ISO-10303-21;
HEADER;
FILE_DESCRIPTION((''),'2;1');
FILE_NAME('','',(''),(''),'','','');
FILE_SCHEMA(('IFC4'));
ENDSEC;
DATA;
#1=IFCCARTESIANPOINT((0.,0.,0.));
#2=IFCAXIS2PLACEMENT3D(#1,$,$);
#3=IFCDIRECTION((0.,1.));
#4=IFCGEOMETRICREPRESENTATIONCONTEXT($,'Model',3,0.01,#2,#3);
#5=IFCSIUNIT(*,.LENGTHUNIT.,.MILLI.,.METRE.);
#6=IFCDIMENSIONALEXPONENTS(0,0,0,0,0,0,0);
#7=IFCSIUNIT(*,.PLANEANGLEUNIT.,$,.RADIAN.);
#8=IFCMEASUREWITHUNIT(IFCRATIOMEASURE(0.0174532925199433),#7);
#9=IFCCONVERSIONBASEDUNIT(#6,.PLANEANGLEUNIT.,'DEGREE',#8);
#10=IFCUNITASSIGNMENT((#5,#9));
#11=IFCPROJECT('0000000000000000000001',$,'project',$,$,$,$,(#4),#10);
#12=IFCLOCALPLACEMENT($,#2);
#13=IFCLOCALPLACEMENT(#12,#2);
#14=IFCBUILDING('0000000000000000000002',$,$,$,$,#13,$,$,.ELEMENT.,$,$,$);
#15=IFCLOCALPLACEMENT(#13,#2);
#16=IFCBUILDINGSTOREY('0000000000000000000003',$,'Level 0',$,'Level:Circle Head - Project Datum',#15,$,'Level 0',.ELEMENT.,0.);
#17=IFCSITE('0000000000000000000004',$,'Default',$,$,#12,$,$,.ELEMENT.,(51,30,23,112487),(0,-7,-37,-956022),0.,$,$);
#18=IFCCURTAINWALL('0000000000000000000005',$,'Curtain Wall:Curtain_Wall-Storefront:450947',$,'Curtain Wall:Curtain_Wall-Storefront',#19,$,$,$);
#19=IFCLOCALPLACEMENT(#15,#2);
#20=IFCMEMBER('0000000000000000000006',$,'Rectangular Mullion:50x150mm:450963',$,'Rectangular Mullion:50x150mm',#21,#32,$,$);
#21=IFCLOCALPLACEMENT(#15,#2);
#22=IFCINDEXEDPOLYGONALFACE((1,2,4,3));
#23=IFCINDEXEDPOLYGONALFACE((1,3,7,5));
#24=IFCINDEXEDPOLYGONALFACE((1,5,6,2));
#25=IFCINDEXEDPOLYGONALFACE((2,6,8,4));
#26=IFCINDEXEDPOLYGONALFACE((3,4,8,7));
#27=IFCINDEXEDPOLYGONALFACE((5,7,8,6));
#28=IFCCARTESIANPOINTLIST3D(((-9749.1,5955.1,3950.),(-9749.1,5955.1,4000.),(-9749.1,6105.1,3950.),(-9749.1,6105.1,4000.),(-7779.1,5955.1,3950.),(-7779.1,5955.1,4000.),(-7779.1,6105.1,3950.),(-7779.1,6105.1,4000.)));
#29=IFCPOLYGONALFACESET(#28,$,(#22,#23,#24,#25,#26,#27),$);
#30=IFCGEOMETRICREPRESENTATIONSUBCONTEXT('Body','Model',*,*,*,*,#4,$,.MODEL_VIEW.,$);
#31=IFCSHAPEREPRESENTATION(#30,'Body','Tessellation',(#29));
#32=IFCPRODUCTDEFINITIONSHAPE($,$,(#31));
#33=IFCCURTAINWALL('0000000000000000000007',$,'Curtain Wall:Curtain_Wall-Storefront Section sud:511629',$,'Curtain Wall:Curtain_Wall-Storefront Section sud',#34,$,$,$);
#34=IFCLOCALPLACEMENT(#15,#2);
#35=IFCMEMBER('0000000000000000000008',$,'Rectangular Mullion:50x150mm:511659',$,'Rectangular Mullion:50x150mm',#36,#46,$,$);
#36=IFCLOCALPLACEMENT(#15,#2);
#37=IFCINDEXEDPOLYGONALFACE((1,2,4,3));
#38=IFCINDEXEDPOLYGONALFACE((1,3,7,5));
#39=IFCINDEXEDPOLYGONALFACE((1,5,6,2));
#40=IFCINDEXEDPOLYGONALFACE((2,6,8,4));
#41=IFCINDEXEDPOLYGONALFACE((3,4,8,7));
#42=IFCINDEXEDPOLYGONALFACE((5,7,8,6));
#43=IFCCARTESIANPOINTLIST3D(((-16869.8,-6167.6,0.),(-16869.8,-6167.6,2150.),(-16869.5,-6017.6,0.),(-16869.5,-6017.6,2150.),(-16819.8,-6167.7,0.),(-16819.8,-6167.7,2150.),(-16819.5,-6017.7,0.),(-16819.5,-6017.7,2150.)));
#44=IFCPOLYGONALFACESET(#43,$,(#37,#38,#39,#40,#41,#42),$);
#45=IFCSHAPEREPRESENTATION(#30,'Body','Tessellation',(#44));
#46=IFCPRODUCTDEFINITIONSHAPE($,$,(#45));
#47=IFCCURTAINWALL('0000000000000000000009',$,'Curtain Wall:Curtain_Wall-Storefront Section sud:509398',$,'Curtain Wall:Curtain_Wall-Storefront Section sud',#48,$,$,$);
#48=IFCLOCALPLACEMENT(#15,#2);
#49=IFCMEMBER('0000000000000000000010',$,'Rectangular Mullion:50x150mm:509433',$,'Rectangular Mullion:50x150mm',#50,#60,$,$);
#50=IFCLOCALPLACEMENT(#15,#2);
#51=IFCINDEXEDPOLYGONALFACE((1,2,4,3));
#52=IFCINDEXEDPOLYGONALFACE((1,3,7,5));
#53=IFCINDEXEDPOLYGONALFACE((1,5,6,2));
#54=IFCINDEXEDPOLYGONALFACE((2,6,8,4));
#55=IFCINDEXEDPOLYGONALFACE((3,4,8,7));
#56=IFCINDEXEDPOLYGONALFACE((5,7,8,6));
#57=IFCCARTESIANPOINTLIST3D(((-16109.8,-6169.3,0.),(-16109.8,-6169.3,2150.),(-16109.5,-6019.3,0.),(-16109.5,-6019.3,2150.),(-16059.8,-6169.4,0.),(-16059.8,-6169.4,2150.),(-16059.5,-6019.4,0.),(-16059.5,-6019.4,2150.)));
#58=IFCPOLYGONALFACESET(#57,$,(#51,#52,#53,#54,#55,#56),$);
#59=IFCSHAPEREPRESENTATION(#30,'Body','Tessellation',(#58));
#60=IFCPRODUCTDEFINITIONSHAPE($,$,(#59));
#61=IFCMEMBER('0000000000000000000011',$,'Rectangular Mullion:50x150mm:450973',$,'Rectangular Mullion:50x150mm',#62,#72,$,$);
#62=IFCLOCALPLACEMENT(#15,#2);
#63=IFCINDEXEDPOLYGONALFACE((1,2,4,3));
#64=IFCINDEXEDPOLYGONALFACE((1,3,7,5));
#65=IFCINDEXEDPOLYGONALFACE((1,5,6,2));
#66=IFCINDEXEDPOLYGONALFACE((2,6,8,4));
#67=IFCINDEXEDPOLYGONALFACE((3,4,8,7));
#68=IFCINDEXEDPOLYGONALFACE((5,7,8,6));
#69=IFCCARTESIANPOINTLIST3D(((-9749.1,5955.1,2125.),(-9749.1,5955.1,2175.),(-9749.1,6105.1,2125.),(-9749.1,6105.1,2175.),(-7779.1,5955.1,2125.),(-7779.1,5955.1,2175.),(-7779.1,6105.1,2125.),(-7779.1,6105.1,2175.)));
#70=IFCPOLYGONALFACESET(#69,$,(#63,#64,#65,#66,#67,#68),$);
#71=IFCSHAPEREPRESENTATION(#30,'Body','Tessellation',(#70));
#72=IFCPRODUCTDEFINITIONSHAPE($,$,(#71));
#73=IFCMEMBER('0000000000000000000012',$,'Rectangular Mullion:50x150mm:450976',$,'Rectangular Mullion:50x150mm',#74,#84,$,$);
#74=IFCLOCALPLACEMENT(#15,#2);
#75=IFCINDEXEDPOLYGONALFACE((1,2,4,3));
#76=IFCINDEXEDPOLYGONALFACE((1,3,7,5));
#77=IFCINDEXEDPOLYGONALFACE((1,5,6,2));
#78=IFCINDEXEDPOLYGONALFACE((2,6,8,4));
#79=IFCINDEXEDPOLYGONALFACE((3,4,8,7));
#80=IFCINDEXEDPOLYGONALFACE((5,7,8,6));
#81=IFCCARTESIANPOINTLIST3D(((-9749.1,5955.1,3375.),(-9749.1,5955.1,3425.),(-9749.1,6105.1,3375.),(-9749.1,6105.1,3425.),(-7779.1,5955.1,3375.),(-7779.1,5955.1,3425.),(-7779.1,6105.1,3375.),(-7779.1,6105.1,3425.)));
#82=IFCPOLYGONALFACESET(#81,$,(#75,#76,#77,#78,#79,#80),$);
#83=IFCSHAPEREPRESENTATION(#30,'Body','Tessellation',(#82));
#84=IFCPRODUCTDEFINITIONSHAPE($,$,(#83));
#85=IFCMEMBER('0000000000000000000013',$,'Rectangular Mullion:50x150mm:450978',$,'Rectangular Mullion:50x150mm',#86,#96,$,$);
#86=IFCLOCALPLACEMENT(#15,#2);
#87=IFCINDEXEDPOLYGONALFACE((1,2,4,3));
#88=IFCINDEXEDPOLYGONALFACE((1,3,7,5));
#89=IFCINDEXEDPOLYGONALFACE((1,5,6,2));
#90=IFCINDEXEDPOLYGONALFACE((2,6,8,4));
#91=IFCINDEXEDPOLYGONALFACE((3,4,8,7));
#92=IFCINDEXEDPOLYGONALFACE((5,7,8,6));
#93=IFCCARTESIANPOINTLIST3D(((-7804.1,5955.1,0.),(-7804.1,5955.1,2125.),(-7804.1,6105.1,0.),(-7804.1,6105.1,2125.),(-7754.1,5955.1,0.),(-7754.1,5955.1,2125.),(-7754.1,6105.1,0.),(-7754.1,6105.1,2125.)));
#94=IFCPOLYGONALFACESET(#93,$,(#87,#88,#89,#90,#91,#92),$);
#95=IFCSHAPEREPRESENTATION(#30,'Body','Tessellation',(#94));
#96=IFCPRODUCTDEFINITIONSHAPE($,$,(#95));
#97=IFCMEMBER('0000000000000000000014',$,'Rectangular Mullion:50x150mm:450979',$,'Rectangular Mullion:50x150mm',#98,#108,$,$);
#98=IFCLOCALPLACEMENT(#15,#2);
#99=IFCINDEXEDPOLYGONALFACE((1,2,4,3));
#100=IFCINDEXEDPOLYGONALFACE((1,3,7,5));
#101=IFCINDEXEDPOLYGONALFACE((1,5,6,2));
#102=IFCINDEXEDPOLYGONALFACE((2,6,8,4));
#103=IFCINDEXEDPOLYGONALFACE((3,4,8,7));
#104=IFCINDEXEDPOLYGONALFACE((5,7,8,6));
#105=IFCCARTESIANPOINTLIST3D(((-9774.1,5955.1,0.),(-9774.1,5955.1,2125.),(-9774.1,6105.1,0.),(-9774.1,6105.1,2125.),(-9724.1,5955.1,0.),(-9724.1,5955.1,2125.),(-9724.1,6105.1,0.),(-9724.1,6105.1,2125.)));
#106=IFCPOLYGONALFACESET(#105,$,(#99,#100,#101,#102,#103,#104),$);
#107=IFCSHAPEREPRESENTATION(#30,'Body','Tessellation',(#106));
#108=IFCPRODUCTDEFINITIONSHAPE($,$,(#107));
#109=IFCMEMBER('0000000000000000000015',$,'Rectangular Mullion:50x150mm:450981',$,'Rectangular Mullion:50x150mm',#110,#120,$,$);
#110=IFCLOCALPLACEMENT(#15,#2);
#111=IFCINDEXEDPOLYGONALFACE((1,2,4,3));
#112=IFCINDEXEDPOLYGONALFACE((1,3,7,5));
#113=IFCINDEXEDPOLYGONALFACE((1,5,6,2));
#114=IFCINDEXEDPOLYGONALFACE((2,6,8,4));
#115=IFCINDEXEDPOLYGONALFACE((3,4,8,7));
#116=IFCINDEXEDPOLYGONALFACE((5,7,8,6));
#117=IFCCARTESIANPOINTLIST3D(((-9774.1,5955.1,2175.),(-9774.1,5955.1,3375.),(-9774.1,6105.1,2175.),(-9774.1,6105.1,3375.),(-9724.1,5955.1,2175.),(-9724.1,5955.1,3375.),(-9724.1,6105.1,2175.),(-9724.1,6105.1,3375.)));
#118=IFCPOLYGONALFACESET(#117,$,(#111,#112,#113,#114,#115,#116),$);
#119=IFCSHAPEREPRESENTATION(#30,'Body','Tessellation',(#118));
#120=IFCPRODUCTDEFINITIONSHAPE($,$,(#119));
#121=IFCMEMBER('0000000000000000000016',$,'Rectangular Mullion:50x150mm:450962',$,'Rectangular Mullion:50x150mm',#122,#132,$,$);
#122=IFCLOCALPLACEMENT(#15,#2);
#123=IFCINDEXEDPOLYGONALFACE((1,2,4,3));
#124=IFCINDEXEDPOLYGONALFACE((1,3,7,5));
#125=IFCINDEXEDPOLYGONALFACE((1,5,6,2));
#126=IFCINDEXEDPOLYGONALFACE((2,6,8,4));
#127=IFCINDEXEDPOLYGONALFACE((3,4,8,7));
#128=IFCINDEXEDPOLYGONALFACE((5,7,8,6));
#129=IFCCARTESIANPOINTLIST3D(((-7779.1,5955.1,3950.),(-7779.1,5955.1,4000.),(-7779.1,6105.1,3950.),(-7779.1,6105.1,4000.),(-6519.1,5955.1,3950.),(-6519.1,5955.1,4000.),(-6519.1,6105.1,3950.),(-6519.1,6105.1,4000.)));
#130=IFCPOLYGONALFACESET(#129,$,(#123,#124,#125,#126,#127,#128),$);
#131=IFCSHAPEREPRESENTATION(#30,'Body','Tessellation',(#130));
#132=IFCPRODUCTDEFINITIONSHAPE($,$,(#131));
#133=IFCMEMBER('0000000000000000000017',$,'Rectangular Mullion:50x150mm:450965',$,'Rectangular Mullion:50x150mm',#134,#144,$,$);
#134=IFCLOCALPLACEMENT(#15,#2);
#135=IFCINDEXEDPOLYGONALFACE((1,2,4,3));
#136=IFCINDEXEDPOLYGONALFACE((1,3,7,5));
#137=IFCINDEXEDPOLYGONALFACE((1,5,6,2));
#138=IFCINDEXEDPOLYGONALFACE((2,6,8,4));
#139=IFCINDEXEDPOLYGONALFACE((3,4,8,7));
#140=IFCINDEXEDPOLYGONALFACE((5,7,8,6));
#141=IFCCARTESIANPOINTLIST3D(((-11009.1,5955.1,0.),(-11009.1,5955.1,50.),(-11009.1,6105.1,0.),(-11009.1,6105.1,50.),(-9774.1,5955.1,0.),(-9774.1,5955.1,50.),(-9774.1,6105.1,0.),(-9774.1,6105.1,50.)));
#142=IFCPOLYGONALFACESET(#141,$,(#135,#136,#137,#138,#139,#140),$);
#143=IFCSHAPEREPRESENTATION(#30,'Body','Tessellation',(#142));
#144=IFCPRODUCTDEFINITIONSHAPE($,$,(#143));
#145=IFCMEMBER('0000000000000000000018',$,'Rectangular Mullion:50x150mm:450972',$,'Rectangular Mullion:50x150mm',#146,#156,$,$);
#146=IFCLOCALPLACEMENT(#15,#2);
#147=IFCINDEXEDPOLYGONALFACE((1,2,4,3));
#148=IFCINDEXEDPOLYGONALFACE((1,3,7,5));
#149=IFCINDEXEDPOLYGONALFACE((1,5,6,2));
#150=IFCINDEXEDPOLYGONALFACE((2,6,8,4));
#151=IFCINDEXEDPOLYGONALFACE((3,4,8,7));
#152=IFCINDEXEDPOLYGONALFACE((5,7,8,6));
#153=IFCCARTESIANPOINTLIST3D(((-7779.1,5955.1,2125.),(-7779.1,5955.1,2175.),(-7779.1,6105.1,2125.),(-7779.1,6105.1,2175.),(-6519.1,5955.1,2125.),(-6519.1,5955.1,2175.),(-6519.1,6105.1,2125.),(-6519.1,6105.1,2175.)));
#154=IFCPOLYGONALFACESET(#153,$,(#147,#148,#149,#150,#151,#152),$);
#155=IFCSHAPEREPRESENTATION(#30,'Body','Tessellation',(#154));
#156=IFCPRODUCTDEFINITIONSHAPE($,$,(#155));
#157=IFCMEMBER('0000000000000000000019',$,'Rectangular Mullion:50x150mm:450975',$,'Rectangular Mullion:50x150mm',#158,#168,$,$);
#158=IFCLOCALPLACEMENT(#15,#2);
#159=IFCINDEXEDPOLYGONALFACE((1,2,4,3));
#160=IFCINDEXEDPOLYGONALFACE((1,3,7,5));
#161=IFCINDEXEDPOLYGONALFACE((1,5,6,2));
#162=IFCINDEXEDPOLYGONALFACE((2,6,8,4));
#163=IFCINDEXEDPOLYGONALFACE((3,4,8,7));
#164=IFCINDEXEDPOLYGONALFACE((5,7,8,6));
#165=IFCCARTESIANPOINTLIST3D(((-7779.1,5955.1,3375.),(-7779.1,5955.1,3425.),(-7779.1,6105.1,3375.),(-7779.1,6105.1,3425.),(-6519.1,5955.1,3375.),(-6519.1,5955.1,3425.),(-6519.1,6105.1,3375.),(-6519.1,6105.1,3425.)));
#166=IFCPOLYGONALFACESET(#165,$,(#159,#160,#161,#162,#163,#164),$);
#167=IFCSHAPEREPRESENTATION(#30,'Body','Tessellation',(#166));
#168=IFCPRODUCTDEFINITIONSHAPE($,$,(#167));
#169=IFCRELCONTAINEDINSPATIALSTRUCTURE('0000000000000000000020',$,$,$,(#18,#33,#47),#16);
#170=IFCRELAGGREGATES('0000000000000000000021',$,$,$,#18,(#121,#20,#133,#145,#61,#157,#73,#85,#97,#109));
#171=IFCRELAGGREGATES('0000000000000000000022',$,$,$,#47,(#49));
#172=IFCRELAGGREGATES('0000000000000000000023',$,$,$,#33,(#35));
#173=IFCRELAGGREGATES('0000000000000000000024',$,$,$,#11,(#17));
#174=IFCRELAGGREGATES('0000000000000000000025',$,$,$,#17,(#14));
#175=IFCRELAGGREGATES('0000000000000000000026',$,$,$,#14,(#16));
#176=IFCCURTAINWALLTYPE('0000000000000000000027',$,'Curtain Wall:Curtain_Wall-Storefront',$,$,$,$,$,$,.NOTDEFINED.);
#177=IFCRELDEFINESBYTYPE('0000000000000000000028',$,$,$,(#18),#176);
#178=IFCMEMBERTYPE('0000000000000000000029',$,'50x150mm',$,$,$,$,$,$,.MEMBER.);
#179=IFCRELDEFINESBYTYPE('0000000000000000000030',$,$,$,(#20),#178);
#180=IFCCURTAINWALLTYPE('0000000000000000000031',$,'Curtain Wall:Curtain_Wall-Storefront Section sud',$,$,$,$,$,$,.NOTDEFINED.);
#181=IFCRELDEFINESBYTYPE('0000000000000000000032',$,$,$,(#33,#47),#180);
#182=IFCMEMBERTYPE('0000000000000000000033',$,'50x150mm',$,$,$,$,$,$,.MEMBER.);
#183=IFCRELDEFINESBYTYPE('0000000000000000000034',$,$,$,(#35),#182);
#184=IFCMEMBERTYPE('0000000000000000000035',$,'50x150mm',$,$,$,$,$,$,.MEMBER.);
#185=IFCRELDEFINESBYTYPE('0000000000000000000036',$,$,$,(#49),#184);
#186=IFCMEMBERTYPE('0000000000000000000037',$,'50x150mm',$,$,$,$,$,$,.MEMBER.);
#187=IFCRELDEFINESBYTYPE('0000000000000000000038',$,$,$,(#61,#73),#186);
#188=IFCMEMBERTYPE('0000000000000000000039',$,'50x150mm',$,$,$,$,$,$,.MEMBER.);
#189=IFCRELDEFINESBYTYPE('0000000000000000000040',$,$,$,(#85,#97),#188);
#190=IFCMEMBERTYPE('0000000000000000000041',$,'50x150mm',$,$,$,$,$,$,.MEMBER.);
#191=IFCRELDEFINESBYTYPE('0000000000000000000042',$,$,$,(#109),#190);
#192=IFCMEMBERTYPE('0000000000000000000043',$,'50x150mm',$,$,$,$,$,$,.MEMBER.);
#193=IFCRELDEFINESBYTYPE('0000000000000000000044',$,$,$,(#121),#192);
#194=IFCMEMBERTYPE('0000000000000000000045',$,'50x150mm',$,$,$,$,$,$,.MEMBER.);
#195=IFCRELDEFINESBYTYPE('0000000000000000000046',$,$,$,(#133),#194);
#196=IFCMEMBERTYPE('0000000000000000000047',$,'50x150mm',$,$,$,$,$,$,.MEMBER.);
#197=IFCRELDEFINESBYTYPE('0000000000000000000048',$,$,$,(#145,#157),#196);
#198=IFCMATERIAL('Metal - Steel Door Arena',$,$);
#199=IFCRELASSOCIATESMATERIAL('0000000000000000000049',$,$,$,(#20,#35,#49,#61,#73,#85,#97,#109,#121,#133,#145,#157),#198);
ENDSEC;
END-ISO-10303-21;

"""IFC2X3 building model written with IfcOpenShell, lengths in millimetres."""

from ifc_helpers import new_model, entity, si_unit, converted_unit, direction, frame, origin, origin_2d_with_axis, place, context, subcontext, project, spatial, rectangle, extrude, source, transform, mapped, material, type_object, type_shapes, element, aggregate, save


model = new_model("IFC2X3")

# Units and contexts
model_context = context("Model", 3, precision=0.01, world=origin(), true_north=direction((0.0, 1.0)))
body_context = subcontext(model_context, "Body", "Model", "MODEL_VIEW")
ifc_project = project(units=[si_unit("LENGTHUNIT", "METRE", prefix="MILLI"), converted_unit("PLANEANGLEUNIT", "DEGREE", entity("IfcRatioMeasure", 0.0174532925199433), si_unit("PLANEANGLEUNIT", "RADIAN"), dimensions=[0, 0, 0, 0, 0, 0, 0])], contexts=[model_context])

# Site, building, storey
site_placement = place(None, origin())
site = spatial("IfcSite", under=ifc_project, at=site_placement, Name="Default", CompositionType="ELEMENT", RefLatitude=(51, 30, 23, 112487), RefLongitude=(0, -7, -37, -956022), RefElevation=0.0)
building_placement = place(site_placement, origin())
building = spatial("IfcBuilding", under=site, at=building_placement, CompositionType="ELEMENT")
storey_placement = place(building_placement, origin())
storey = spatial("IfcBuildingStorey", under=building, at=storey_placement, Name="Level 0", ObjectType="Level:Circle Head - Project Datum", LongName="Level 0", CompositionType="ELEMENT", Elevation=0.0)

# Curtain walls, members
curtain_wall_type_1 = type_object("IfcCurtainWallType", Name="Curtain Wall:Curtain_Wall-Storefront", PredefinedType="NOTDEFINED")
curtain_wall_1_placement = place(storey_placement, origin())
curtain_wall_1 = element("IfcCurtainWall", 1, at=curtain_wall_1_placement, inside=storey, type_object=curtain_wall_type_1, Name="Curtain Wall:Curtain_Wall-Storefront:450947", ObjectType="Curtain Wall:Curtain_Wall-Storefront")
ifc_material_1 = material(Name="Metal - Steel Door Arena")
member_type_1 = type_object("IfcMemberType", Name="50x150mm", PredefinedType="MEMBER")
shared_shape_1 = source(origin(), body_context, "Body", "SweptSolid", [
    extrude(rectangle(XDim=150.0, YDim=50.0, at=origin_2d_with_axis()), frame((-25.0, 0.0, -1970.0), z_axis=(0.0, 0.0, 1.0), x_axis=(0.0, -1.0, 0.0)), (0.0, 0.0, 1.0), 1970.0),
])
type_shapes(member_type_1, [shared_shape_1])
member_1_placement = place(storey_placement, frame((-9749.1, 6030.1, 4000.0), z_axis=(-1.0, 0.0, 0.0), x_axis=(0.0, 0.0, 1.0)))
member_1 = element("IfcMember", 2, at=member_1_placement, type_object=member_type_1, material=ifc_material_1, Name="Rectangular Mullion:50x150mm:450963", ObjectType="Rectangular Mullion:50x150mm", context=body_context, shape_type="MappedRepresentation", body=[
    mapped(shared_shape_1, transform((0.0, 0.0, 0.0), scale=1.0)),
])
curtain_wall_type_2 = type_object("IfcCurtainWallType", Name="Curtain Wall:Curtain_Wall-Storefront Section sud", PredefinedType="NOTDEFINED")
curtain_wall_2_placement = place(storey_placement, origin())
curtain_wall_2 = element("IfcCurtainWall", 3, at=curtain_wall_2_placement, inside=storey, type_object=curtain_wall_type_2, Name="Curtain Wall:Curtain_Wall-Storefront Section sud:511629", ObjectType="Curtain Wall:Curtain_Wall-Storefront Section sud")
member_type_2 = type_object("IfcMemberType", Name="50x150mm", PredefinedType="MEMBER")
shared_shape_2 = source(origin(), body_context, "Body", "SweptSolid", [
    extrude(rectangle(XDim=150.0, YDim=50.0, at=origin_2d_with_axis()), frame((-25.0, 0.0, -2150.0), z_axis=(0.0, 0.0, 1.0), x_axis=(0.0, -1.0, 0.0)), (0.0, 0.0, 1.0), 2150.0),
])
type_shapes(member_type_2, [shared_shape_2])
member_2_placement = place(storey_placement, frame((-16819.6, -6092.7, 0.0), z_axis=(0.0, 0.0, -1.0), x_axis=(0.999998, -0.002199, 0.0)))
member_2 = element("IfcMember", 4, at=member_2_placement, type_object=member_type_2, material=ifc_material_1, Name="Rectangular Mullion:50x150mm:511659", ObjectType="Rectangular Mullion:50x150mm", context=body_context, shape_type="MappedRepresentation", body=[
    mapped(shared_shape_2, transform((0.0, 0.0, 0.0), scale=1.0)),
])
curtain_wall_3_placement = place(storey_placement, origin())
curtain_wall_3 = element("IfcCurtainWall", 5, at=curtain_wall_3_placement, inside=storey, type_object=curtain_wall_type_2, Name="Curtain Wall:Curtain_Wall-Storefront Section sud:509398", ObjectType="Curtain Wall:Curtain_Wall-Storefront Section sud")
member_type_3 = type_object("IfcMemberType", Name="50x150mm", PredefinedType="MEMBER")
shared_shape_3 = source(origin(), body_context, "Body", "SweptSolid", [
    extrude(rectangle(XDim=150.0, YDim=50.0, at=origin_2d_with_axis()), frame((-25.0, 0.0, -2150.0), z_axis=(0.0, 0.0, 1.0), x_axis=(0.0, -1.0, 0.0)), (0.0, 0.0, 1.0), 2150.0),
])
type_shapes(member_type_3, [shared_shape_3])
member_3_placement = place(storey_placement, frame((-16109.6, -6094.3, 2150.0), z_axis=(0.0, 0.0, 1.0), x_axis=(-0.999998, 0.002199, 0.0)))
member_3 = element("IfcMember", 6, at=member_3_placement, type_object=member_type_3, material=ifc_material_1, Name="Rectangular Mullion:50x150mm:509433", ObjectType="Rectangular Mullion:50x150mm", context=body_context, shape_type="MappedRepresentation", body=[
    mapped(shared_shape_3, transform((0.0, 0.0, 0.0), scale=1.0)),
])

# Members
member_type_4 = type_object("IfcMemberType", Name="50x150mm", PredefinedType="MEMBER")
shared_shape_4 = source(origin(), body_context, "Body", "SweptSolid", [
    extrude(rectangle(XDim=150.0, YDim=50.0, at=origin_2d_with_axis()), frame((0.0, 0.0, -1970.0), z_axis=(0.0, 0.0, 1.0), x_axis=(0.0, -1.0, 0.0)), (0.0, 0.0, 1.0), 1970.0),
])
type_shapes(member_type_4, [shared_shape_4])
member_4_placement = place(storey_placement, frame((-9749.1, 6030.1, 2150.0), z_axis=(-1.0, 0.0, 0.0), x_axis=(0.0, 0.0, 1.0)))
member_4 = element("IfcMember", 7, at=member_4_placement, type_object=member_type_4, material=ifc_material_1, Name="Rectangular Mullion:50x150mm:450973", ObjectType="Rectangular Mullion:50x150mm", context=body_context, shape_type="MappedRepresentation", body=[
    mapped(shared_shape_4, transform((0.0, 0.0, 0.0), scale=1.0)),
])
member_5_placement = place(storey_placement, frame((-9749.1, 6030.1, 3400.0), z_axis=(-1.0, 0.0, 0.0), x_axis=(0.0, 0.0, 1.0)))
member_5 = element("IfcMember", 8, at=member_5_placement, type_object=member_type_4, material=ifc_material_1, Name="Rectangular Mullion:50x150mm:450976", ObjectType="Rectangular Mullion:50x150mm", context=body_context, shape_type="MappedRepresentation", body=[
    mapped(shared_shape_4, transform((0.0, 0.0, 0.0), scale=1.0)),
])
member_type_5 = type_object("IfcMemberType", Name="50x150mm", PredefinedType="MEMBER")
shared_shape_5 = source(origin(), body_context, "Body", "SweptSolid", [
    extrude(rectangle(XDim=150.0, YDim=50.0, at=origin_2d_with_axis()), frame((0.0, 0.0, -2125.0), z_axis=(0.0, 0.0, 1.0), x_axis=(0.0, -1.0, 0.0)), (0.0, 0.0, 1.0), 2125.0),
])
type_shapes(member_type_5, [shared_shape_5])
member_6_placement = place(storey_placement, frame((-7779.1, 6030.1, 0.0), z_axis=(0.0, 0.0, -1.0), x_axis=(-1.0, 0.0, 0.0)))
member_6 = element("IfcMember", 9, at=member_6_placement, type_object=member_type_5, material=ifc_material_1, Name="Rectangular Mullion:50x150mm:450978", ObjectType="Rectangular Mullion:50x150mm", context=body_context, shape_type="MappedRepresentation", body=[
    mapped(shared_shape_5, transform((0.0, 0.0, 0.0), scale=1.0)),
])
member_7_placement = place(storey_placement, frame((-9749.1, 6030.1, 0.0), z_axis=(0.0, 0.0, -1.0), x_axis=(-1.0, 0.0, 0.0)))
member_7 = element("IfcMember", 10, at=member_7_placement, type_object=member_type_5, material=ifc_material_1, Name="Rectangular Mullion:50x150mm:450979", ObjectType="Rectangular Mullion:50x150mm", context=body_context, shape_type="MappedRepresentation", body=[
    mapped(shared_shape_5, transform((0.0, 0.0, 0.0), scale=1.0)),
])
member_type_6 = type_object("IfcMemberType", Name="50x150mm", PredefinedType="MEMBER")
shared_shape_6 = source(origin(), body_context, "Body", "SweptSolid", [
    extrude(rectangle(XDim=150.0, YDim=50.0, at=origin_2d_with_axis()), frame((0.0, 0.0, -1200.0), z_axis=(0.0, 0.0, 1.0), x_axis=(0.0, -1.0, 0.0)), (0.0, 0.0, 1.0), 1200.0),
])
type_shapes(member_type_6, [shared_shape_6])
member_8_placement = place(storey_placement, frame((-9749.1, 6030.1, 2175.0), z_axis=(0.0, 0.0, -1.0), x_axis=(-1.0, 0.0, 0.0)))
member_8 = element("IfcMember", 11, at=member_8_placement, type_object=member_type_6, material=ifc_material_1, Name="Rectangular Mullion:50x150mm:450981", ObjectType="Rectangular Mullion:50x150mm", context=body_context, shape_type="MappedRepresentation", body=[
    mapped(shared_shape_6, transform((0.0, 0.0, 0.0), scale=1.0)),
])
member_type_7 = type_object("IfcMemberType", Name="50x150mm", PredefinedType="MEMBER")
shared_shape_7 = source(origin(), body_context, "Body", "SweptSolid", [
    extrude(rectangle(XDim=150.0, YDim=50.0, at=origin_2d_with_axis()), frame((-25.0, 0.0, -1260.0), z_axis=(0.0, 0.0, 1.0), x_axis=(0.0, -1.0, 0.0)), (0.0, 0.0, 1.0), 1260.0),
])
type_shapes(member_type_7, [shared_shape_7])
member_9_placement = place(storey_placement, frame((-7779.1, 6030.1, 4000.0), z_axis=(-1.0, 0.0, 0.0), x_axis=(0.0, 0.0, 1.0)))
member_9 = element("IfcMember", 12, at=member_9_placement, type_object=member_type_7, material=ifc_material_1, Name="Rectangular Mullion:50x150mm:450962", ObjectType="Rectangular Mullion:50x150mm", context=body_context, shape_type="MappedRepresentation", body=[
    mapped(shared_shape_7, transform((0.0, 0.0, 0.0), scale=1.0)),
])
member_type_8 = type_object("IfcMemberType", Name="50x150mm", PredefinedType="MEMBER")
shared_shape_8 = source(origin(), body_context, "Body", "SweptSolid", [
    extrude(rectangle(XDim=150.0, YDim=50.0, at=origin_2d_with_axis()), frame((-25.0, 0.0, -1235.0), z_axis=(0.0, 0.0, 1.0), x_axis=(0.0, -1.0, 0.0)), (0.0, 0.0, 1.0), 1235.0),
])
type_shapes(member_type_8, [shared_shape_8])
member_10_placement = place(storey_placement, frame((-9774.1, 6030.1, 0.0), z_axis=(1.0, 0.0, 0.0), x_axis=(0.0, 0.0, -1.0)))
member_10 = element("IfcMember", 13, at=member_10_placement, type_object=member_type_8, material=ifc_material_1, Name="Rectangular Mullion:50x150mm:450965", ObjectType="Rectangular Mullion:50x150mm", context=body_context, shape_type="MappedRepresentation", body=[
    mapped(shared_shape_8, transform((0.0, 0.0, 0.0), scale=1.0)),
])
member_type_9 = type_object("IfcMemberType", Name="50x150mm", PredefinedType="MEMBER")
shared_shape_9 = source(origin(), body_context, "Body", "SweptSolid", [
    extrude(rectangle(XDim=150.0, YDim=50.0, at=origin_2d_with_axis()), frame((0.0, 0.0, -1260.0), z_axis=(0.0, 0.0, 1.0), x_axis=(0.0, -1.0, 0.0)), (0.0, 0.0, 1.0), 1260.0),
])
type_shapes(member_type_9, [shared_shape_9])
member_11_placement = place(storey_placement, frame((-7779.1, 6030.1, 2150.0), z_axis=(-1.0, 0.0, 0.0), x_axis=(0.0, 0.0, 1.0)))
member_11 = element("IfcMember", 14, at=member_11_placement, type_object=member_type_9, material=ifc_material_1, Name="Rectangular Mullion:50x150mm:450972", ObjectType="Rectangular Mullion:50x150mm", context=body_context, shape_type="MappedRepresentation", body=[
    mapped(shared_shape_9, transform((0.0, 0.0, 0.0), scale=1.0)),
])
member_12_placement = place(storey_placement, frame((-7779.1, 6030.1, 3400.0), z_axis=(-1.0, 0.0, 0.0), x_axis=(0.0, 0.0, 1.0)))
member_12 = element("IfcMember", 15, at=member_12_placement, type_object=member_type_9, material=ifc_material_1, Name="Rectangular Mullion:50x150mm:450975", ObjectType="Rectangular Mullion:50x150mm", context=body_context, shape_type="MappedRepresentation", body=[
    mapped(shared_shape_9, transform((0.0, 0.0, 0.0), scale=1.0)),
])

aggregate(curtain_wall_1, [member_9, member_1, member_10, member_11, member_4, member_12, member_5, member_6, member_7, member_8])
aggregate(curtain_wall_3, [member_3])
aggregate(curtain_wall_2, [member_2])

save(model, "model.ifc")
